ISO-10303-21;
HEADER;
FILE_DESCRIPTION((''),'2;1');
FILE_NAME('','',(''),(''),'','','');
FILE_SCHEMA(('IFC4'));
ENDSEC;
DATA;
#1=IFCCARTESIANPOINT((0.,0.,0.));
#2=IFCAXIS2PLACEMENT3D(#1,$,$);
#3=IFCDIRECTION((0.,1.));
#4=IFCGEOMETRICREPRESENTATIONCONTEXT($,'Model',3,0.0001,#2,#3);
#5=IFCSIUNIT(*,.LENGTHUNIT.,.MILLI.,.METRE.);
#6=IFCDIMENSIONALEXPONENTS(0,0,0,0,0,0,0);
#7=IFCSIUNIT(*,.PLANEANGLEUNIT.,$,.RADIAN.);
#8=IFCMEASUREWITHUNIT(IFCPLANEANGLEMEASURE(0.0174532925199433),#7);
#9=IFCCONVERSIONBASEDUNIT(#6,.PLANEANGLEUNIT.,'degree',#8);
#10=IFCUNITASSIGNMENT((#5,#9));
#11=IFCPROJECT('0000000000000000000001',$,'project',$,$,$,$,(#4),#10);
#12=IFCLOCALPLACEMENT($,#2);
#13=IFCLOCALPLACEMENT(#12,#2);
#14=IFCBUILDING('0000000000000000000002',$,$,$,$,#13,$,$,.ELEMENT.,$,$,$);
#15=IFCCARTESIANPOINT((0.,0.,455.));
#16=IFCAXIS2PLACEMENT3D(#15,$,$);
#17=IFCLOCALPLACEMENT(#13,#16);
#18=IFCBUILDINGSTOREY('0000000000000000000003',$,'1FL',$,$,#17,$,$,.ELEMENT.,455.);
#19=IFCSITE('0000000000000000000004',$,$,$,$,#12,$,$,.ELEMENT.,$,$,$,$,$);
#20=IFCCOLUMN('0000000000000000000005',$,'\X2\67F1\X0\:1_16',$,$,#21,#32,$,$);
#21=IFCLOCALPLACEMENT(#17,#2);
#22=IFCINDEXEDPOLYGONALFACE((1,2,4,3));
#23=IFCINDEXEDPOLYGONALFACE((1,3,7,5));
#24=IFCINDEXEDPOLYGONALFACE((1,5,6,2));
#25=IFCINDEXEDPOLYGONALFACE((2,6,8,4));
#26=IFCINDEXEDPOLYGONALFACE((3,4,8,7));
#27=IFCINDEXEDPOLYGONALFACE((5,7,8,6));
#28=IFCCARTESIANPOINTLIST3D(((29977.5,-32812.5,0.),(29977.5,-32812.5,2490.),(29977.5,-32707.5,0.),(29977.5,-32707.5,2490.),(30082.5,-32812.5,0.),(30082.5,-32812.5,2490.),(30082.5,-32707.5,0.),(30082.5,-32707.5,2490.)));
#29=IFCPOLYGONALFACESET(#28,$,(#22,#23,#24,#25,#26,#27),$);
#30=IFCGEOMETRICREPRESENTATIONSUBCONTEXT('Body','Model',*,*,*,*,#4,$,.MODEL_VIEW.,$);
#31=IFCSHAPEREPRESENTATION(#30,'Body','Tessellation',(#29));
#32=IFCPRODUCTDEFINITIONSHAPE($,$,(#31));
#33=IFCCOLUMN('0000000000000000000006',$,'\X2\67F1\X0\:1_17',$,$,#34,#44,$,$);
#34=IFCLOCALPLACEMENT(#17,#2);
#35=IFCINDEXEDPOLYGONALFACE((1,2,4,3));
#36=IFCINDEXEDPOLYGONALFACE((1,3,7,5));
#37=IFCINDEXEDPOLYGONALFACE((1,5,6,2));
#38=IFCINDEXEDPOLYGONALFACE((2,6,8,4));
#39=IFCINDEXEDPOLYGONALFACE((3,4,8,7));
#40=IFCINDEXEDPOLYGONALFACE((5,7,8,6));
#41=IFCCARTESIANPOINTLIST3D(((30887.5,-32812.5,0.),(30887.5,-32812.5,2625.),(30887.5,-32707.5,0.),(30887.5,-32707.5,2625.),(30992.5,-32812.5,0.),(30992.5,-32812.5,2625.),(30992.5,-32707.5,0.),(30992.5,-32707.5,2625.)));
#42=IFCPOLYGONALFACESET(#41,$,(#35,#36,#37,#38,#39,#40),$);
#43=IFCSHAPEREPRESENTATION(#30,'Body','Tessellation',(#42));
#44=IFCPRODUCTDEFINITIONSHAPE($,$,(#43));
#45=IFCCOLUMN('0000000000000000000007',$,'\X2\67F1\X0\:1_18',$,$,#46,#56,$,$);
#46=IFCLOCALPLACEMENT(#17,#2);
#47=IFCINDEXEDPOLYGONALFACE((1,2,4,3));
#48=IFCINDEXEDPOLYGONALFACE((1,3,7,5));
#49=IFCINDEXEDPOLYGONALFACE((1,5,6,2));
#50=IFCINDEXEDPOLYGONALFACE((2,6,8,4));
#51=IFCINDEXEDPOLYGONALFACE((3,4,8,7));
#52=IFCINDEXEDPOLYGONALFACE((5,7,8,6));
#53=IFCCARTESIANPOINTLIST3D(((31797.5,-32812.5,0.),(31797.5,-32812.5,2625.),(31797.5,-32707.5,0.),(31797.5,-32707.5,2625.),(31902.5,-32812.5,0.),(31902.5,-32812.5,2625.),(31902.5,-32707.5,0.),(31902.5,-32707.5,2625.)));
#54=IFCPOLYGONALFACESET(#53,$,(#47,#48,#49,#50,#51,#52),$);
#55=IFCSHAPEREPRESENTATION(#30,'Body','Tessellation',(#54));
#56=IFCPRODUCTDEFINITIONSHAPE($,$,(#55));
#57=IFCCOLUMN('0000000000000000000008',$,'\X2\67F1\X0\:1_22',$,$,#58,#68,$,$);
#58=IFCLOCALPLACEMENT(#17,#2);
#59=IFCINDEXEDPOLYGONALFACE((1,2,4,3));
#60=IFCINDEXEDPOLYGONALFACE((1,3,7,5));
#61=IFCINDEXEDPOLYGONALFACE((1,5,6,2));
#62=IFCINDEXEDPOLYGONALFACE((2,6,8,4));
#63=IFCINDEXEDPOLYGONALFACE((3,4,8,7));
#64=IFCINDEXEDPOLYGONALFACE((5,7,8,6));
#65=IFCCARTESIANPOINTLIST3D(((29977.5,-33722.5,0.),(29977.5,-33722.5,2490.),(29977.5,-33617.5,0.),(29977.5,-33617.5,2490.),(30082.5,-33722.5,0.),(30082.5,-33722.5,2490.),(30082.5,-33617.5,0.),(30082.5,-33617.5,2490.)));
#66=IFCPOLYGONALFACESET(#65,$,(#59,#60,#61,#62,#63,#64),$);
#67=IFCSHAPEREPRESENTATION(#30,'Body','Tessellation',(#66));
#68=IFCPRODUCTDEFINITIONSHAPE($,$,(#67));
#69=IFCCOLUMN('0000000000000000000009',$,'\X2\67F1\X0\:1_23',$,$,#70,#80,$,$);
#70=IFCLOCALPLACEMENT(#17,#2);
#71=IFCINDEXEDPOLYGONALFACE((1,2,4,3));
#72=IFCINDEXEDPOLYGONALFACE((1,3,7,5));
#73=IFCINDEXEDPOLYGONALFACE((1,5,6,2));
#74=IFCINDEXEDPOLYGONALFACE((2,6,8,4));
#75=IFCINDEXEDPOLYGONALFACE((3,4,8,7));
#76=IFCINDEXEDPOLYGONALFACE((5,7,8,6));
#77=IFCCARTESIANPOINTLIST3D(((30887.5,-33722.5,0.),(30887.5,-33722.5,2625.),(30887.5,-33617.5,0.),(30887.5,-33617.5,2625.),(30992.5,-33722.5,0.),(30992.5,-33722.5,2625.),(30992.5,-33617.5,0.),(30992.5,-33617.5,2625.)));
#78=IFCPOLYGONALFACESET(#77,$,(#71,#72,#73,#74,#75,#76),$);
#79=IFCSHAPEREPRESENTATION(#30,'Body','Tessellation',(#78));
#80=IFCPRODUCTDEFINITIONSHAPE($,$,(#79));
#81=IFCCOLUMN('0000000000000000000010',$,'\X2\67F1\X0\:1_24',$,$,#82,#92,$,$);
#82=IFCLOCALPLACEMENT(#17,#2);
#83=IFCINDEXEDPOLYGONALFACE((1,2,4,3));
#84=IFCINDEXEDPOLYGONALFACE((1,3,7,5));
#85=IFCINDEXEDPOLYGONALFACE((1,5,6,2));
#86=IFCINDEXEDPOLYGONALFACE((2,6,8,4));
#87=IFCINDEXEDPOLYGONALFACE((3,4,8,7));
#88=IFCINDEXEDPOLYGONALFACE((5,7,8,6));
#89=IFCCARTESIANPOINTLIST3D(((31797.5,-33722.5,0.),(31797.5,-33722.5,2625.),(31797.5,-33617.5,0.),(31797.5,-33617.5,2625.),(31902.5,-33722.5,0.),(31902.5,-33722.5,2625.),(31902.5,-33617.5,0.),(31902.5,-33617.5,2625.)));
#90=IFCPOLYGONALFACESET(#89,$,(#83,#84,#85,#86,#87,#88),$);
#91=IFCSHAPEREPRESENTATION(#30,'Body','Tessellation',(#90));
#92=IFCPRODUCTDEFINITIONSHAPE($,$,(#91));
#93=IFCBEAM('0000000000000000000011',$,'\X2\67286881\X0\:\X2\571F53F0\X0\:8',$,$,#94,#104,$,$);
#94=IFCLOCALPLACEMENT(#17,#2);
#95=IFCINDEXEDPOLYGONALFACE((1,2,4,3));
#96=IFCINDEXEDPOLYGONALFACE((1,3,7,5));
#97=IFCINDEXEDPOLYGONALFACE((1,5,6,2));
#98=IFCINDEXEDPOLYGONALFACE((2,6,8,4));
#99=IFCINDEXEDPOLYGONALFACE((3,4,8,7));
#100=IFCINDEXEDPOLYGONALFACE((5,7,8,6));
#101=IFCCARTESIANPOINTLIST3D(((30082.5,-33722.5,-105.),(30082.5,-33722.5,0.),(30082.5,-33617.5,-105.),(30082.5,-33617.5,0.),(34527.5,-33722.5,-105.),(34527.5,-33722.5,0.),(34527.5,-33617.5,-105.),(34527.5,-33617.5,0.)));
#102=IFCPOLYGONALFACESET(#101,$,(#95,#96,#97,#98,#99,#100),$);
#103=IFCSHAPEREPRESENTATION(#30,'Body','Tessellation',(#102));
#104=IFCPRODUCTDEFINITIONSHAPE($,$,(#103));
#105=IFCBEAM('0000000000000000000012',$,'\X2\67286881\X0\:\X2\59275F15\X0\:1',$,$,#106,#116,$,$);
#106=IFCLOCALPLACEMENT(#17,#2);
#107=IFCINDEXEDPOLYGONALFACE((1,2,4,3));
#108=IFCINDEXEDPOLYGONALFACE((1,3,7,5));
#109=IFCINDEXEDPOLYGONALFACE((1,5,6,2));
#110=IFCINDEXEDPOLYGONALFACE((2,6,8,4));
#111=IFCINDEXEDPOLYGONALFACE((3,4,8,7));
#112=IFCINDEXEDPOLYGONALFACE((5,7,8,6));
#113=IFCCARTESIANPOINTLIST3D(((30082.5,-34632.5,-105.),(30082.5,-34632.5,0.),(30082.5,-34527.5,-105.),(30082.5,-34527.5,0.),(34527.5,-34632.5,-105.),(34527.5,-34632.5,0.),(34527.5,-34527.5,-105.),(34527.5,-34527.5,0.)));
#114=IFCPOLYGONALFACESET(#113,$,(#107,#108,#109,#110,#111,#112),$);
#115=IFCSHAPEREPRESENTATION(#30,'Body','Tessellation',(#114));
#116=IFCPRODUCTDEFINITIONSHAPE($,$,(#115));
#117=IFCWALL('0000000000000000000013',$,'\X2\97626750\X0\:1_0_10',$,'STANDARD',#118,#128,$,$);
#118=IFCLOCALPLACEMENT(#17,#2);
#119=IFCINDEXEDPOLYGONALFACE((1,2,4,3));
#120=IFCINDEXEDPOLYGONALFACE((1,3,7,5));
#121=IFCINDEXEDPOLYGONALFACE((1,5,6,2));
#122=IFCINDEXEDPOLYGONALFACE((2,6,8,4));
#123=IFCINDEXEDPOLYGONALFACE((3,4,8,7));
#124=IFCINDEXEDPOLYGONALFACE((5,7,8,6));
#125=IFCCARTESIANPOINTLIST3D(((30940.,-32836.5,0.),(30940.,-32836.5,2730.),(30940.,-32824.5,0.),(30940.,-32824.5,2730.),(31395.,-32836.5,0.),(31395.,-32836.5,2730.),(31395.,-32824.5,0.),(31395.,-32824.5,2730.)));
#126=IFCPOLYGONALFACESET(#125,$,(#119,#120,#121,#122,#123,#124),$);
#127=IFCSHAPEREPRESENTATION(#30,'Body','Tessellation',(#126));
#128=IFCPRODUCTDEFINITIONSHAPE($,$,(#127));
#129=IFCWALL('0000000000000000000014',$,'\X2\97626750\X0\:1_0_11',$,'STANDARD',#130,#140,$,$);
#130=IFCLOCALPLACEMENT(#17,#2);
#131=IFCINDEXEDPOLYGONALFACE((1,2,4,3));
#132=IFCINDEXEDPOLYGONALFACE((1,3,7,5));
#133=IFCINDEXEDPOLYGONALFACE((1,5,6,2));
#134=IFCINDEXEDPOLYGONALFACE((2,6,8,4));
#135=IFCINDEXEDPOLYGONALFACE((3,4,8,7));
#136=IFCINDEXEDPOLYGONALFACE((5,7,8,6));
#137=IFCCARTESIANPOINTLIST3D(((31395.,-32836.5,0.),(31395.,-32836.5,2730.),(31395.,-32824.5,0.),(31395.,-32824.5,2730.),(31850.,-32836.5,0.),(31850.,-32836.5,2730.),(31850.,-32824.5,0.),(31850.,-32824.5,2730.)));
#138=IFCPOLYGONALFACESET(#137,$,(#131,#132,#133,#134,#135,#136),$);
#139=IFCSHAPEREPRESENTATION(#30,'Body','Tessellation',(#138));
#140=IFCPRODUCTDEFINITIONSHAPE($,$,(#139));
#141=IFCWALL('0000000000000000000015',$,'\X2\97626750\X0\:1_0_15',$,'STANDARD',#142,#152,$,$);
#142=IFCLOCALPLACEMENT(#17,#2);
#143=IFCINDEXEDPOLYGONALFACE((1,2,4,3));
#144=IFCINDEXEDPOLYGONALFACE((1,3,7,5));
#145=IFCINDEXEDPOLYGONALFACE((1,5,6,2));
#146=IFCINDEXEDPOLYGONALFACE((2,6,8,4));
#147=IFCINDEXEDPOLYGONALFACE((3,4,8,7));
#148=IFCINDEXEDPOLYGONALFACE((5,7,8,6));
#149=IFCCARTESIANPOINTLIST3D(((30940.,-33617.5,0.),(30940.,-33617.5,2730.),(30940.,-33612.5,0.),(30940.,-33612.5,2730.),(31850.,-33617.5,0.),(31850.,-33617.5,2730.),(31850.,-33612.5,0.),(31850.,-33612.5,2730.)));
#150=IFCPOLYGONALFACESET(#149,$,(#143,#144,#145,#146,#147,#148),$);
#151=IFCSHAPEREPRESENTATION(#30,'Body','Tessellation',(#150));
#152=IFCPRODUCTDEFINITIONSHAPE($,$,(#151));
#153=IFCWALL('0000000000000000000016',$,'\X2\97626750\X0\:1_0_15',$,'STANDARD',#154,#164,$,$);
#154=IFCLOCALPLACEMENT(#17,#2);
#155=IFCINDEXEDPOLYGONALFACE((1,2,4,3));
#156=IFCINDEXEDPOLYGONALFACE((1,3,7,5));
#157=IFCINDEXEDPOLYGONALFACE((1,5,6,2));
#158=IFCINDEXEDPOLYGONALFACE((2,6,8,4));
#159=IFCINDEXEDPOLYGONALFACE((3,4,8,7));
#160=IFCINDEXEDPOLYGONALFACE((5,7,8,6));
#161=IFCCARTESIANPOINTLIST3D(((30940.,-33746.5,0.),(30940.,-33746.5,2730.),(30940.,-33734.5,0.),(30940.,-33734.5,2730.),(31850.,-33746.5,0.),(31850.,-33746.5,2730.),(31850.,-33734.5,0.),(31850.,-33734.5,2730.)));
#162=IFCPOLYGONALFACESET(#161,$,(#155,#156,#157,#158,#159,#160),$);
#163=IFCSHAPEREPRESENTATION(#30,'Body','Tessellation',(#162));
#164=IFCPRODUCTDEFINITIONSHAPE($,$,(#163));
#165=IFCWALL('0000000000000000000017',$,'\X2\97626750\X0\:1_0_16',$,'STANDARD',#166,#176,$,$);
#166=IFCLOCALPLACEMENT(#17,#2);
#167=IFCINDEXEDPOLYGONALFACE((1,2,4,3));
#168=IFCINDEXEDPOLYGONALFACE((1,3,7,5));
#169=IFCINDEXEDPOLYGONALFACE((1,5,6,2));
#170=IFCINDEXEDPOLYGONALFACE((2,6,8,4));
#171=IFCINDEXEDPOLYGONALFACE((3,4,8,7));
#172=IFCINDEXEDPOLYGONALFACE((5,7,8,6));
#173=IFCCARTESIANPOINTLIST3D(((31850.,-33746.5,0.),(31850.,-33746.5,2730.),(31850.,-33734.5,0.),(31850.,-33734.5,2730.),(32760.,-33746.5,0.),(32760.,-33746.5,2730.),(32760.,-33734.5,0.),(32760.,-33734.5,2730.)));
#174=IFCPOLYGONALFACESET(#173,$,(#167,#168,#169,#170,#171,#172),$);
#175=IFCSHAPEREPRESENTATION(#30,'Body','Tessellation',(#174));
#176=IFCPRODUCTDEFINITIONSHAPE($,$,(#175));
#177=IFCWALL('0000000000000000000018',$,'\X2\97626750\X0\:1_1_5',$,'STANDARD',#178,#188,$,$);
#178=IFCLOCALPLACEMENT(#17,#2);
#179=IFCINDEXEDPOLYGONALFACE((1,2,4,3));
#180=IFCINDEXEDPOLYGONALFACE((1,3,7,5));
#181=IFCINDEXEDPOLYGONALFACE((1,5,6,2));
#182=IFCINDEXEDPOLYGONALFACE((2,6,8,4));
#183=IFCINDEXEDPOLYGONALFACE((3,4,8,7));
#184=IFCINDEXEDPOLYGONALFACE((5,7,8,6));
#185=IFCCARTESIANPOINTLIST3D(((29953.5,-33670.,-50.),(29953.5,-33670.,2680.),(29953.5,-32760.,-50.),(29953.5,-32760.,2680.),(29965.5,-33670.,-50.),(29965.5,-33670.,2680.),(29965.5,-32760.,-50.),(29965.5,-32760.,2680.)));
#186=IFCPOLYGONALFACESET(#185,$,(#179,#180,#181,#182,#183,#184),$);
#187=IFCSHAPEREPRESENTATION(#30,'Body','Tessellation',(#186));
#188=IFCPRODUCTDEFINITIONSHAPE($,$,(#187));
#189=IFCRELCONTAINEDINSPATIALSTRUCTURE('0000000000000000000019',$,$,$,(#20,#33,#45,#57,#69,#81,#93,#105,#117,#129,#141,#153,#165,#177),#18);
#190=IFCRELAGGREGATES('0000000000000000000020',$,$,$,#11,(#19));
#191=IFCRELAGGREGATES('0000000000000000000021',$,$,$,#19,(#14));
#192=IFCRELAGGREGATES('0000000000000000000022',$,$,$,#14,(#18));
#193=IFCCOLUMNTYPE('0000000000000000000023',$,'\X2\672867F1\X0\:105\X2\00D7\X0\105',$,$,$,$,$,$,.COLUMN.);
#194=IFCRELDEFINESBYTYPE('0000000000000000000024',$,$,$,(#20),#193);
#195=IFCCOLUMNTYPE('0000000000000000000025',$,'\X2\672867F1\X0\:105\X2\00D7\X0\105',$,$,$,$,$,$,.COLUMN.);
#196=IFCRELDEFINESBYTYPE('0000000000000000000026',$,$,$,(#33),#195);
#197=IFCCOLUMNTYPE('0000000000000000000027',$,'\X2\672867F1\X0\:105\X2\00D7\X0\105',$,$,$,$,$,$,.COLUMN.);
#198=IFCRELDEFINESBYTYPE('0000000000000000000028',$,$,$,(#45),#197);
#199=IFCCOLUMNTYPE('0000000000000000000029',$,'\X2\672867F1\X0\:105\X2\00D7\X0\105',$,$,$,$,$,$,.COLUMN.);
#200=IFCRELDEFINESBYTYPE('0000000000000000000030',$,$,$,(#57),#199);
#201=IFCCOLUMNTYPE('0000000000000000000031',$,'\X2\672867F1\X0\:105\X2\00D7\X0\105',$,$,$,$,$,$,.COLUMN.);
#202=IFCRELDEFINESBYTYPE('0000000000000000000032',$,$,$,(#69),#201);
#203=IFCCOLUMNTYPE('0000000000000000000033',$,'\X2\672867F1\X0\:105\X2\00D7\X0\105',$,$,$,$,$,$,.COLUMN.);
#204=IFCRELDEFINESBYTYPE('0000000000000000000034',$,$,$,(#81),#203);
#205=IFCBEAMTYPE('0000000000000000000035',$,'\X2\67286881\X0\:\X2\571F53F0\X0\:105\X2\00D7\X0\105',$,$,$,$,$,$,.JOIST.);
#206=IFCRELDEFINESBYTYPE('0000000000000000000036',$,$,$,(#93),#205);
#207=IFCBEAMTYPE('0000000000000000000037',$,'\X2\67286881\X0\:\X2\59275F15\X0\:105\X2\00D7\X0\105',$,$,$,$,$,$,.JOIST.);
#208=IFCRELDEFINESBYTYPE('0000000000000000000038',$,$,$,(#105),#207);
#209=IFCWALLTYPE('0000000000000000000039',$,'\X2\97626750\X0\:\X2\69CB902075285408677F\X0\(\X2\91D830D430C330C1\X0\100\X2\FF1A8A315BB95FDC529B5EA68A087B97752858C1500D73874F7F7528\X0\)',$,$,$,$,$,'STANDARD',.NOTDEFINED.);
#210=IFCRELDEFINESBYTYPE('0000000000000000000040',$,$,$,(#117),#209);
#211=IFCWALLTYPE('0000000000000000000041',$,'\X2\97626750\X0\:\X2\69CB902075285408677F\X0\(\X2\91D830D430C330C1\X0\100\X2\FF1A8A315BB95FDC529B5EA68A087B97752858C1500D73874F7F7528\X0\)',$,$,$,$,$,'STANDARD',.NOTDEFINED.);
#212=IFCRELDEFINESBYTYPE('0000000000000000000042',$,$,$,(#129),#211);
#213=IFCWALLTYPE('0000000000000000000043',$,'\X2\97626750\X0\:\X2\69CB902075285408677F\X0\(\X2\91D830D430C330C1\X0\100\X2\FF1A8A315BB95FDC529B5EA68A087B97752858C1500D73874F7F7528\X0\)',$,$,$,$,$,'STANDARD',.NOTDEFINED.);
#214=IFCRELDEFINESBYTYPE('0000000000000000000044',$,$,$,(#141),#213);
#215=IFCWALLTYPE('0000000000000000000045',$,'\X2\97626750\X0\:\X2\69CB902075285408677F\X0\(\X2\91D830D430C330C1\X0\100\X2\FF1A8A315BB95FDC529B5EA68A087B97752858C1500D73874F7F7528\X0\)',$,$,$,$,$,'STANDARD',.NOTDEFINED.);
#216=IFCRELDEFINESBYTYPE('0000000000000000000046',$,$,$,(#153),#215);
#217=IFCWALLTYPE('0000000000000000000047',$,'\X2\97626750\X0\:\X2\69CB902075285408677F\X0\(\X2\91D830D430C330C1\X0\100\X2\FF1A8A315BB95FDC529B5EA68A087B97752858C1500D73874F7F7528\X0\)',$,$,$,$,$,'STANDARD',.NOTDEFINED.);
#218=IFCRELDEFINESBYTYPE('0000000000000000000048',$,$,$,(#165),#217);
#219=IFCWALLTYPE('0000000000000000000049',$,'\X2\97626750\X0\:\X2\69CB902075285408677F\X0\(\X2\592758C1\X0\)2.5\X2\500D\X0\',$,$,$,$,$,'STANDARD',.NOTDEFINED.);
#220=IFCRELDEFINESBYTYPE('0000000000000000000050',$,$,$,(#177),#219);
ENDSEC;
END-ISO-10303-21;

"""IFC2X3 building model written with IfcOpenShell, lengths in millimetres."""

from ifc_helpers import new_model, entity, si_unit, converted_unit, direction, frame, origin, origin_with_axes, origin_2d, place, context, subcontext, project, spatial, polyline, rectangle, outline, extrude, type_object, element, save


model = new_model("IFC2X3")

# Units and contexts
model_context = context("Model", 3, precision=0.0001, world=origin(), true_north=direction((0.0, 1.0)))
body_context = subcontext(model_context, "Body", "Model", "MODEL_VIEW")
ifc_project = project(units=[si_unit("LENGTHUNIT", "METRE", prefix="MILLI"), converted_unit("PLANEANGLEUNIT", "degree", entity("IfcPlaneAngleMeasure", 0.0174532925199433), si_unit("PLANEANGLEUNIT", "RADIAN"), dimensions=[0, 0, 0, 0, 0, 0, 0])], contexts=[model_context])

# Site, building, storey
site_placement = place(None, origin())
site = spatial("IfcSite", under=ifc_project, at=site_placement, CompositionType="ELEMENT")
building_placement = place(site_placement, origin())
building = spatial("IfcBuilding", under=site, at=building_placement, CompositionType="ELEMENT")
storey_placement = place(building_placement, frame((0.0, 0.0, 455.0)))
storey = spatial("IfcBuildingStorey", under=building, at=storey_placement, Name="1FL", CompositionType="ELEMENT", Elevation=455.0)

# Columns
column_type_1 = type_object("IfcColumnType", Name="木柱:105×105", PredefinedType="COLUMN")
column_1_placement = place(storey_placement, frame((30030.0, -32760.0, 0.0)))
element("IfcColumn", 1, at=column_1_placement, inside=storey, type_object=column_type_1, Name="柱:1_16", context=body_context, shape_type="SweptSolid", body=[
    extrude(rectangle(XDim=105.0, YDim=105.0, at=origin_2d()), origin_with_axes(), (0.0, 0.0, 1.0), 2490.0),
])
column_type_2 = type_object("IfcColumnType", Name="木柱:105×105", PredefinedType="COLUMN")
column_2_placement = place(storey_placement, frame((30940.0, -32760.0, 0.0)))
element("IfcColumn", 2, at=column_2_placement, inside=storey, type_object=column_type_2, Name="柱:1_17", context=body_context, shape_type="SweptSolid", body=[
    extrude(rectangle(XDim=105.0, YDim=105.0, at=origin_2d()), origin_with_axes(), (0.0, 0.0, 1.0), 2625.0),
])
column_type_3 = type_object("IfcColumnType", Name="木柱:105×105", PredefinedType="COLUMN")
column_3_placement = place(storey_placement, frame((31850.0, -32760.0, 0.0)))
element("IfcColumn", 3, at=column_3_placement, inside=storey, type_object=column_type_3, Name="柱:1_18", context=body_context, shape_type="SweptSolid", body=[
    extrude(rectangle(XDim=105.0, YDim=105.0, at=origin_2d()), origin_with_axes(), (0.0, 0.0, 1.0), 2625.0),
])
column_type_4 = type_object("IfcColumnType", Name="木柱:105×105", PredefinedType="COLUMN")
column_4_placement = place(storey_placement, frame((30030.0, -33670.0, 0.0)))
element("IfcColumn", 4, at=column_4_placement, inside=storey, type_object=column_type_4, Name="柱:1_22", context=body_context, shape_type="SweptSolid", body=[
    extrude(rectangle(XDim=105.0, YDim=105.0, at=origin_2d()), origin_with_axes(), (0.0, 0.0, 1.0), 2490.0),
])
column_type_5 = type_object("IfcColumnType", Name="木柱:105×105", PredefinedType="COLUMN")
column_5_placement = place(storey_placement, frame((30940.0, -33670.0, 0.0)))
element("IfcColumn", 5, at=column_5_placement, inside=storey, type_object=column_type_5, Name="柱:1_23", context=body_context, shape_type="SweptSolid", body=[
    extrude(rectangle(XDim=105.0, YDim=105.0, at=origin_2d()), origin_with_axes(), (0.0, 0.0, 1.0), 2625.0),
])
column_type_6 = type_object("IfcColumnType", Name="木柱:105×105", PredefinedType="COLUMN")
column_6_placement = place(storey_placement, frame((31850.0, -33670.0, 0.0)))
element("IfcColumn", 6, at=column_6_placement, inside=storey, type_object=column_type_6, Name="柱:1_24", context=body_context, shape_type="SweptSolid", body=[
    extrude(rectangle(XDim=105.0, YDim=105.0, at=origin_2d()), origin_with_axes(), (0.0, 0.0, 1.0), 2625.0),
])

# Beams
beam_type_1 = type_object("IfcBeamType", Name="木梁:土台:105×105", PredefinedType="JOIST")
beam_1_placement = place(storey_placement, frame((30082.5, -33670.0, -52.5), z_axis=(1.0, 0.0, 0.0), x_axis=(0.0, 1.0, 0.0)))
element("IfcBeam", 7, at=beam_1_placement, inside=storey, type_object=beam_type_1, Name="木梁:土台:8", context=body_context, shape_type="SweptSolid", body=[
    extrude(rectangle(XDim=105.0, YDim=105.0, at=origin_2d()), origin_with_axes(), (0.0, 0.0, 1.0), 4445.0),
])
beam_type_2 = type_object("IfcBeamType", Name="木梁:大引:105×105", PredefinedType="JOIST")
beam_2_placement = place(storey_placement, frame((30082.5, -34580.0, -52.5), z_axis=(1.0, 0.0, 0.0), x_axis=(0.0, 1.0, 0.0)))
element("IfcBeam", 8, at=beam_2_placement, inside=storey, type_object=beam_type_2, Name="木梁:大引:1", context=body_context, shape_type="SweptSolid", body=[
    extrude(rectangle(XDim=105.0, YDim=105.0, at=origin_2d()), origin_with_axes(), (0.0, 0.0, 1.0), 4445.0),
])

# Walls
wall_type_1 = type_object("IfcWallType", Name="面材:構造用合板(釘ピッチ100：許容応力度計算用壁倍率使用)", ElementType="STANDARD", PredefinedType="NOTDEFINED")
wall_1_placement = place(storey_placement, frame((31167.5, -32824.5, 0.0), z_axis=(0.0, -1.0, 0.0), x_axis=(1.0, 0.0, 0.0)))
element("IfcWall", 9, at=wall_1_placement, inside=storey, type_object=wall_type_1, Name="面材:1_0_10", ObjectType="STANDARD", context=body_context, shape_type="SweptSolid", body=[
    extrude(outline(polyline([(227.5, 0.0, 0.0), (-227.5, 0.0, 0.0), (-227.5, 2730.0, 0.0), (227.5, 2730.0, 0.0), (227.5, 0.0, 0.0)])), origin_with_axes(), (0.0, 0.0, 1.0), 12.0),
])
wall_type_2 = type_object("IfcWallType", Name="面材:構造用合板(釘ピッチ100：許容応力度計算用壁倍率使用)", ElementType="STANDARD", PredefinedType="NOTDEFINED")
wall_2_placement = place(storey_placement, frame((31622.5, -32824.5, 0.0), z_axis=(0.0, -1.0, 0.0), x_axis=(1.0, 0.0, 0.0)))
element("IfcWall", 10, at=wall_2_placement, inside=storey, type_object=wall_type_2, Name="面材:1_0_11", ObjectType="STANDARD", context=body_context, shape_type="SweptSolid", body=[
    extrude(outline(polyline([(227.5, 0.0, 0.0), (-227.5, 0.0, 0.0), (-227.5, 2730.0, 0.0), (227.5, 2730.0, 0.0), (227.5, 0.0, 0.0)])), origin_with_axes(), (0.0, 0.0, 1.0), 12.0),
])
wall_type_3 = type_object("IfcWallType", Name="面材:構造用合板(釘ピッチ100：許容応力度計算用壁倍率使用)", ElementType="STANDARD", PredefinedType="NOTDEFINED")
wall_3_placement = place(storey_placement, frame((31395.0, -33612.5, 0.0), z_axis=(0.0, -1.0, 0.0), x_axis=(1.0, 0.0, 0.0)))
element("IfcWall", 11, at=wall_3_placement, inside=storey, type_object=wall_type_3, Name="面材:1_0_15", ObjectType="STANDARD", context=body_context, shape_type="SweptSolid", body=[
    extrude(outline(polyline([(455.0, 0.0, 0.0), (-455.0, 0.0, 0.0), (-455.0, 2730.0, 0.0), (455.0, 2730.0, 0.0), (455.0, 0.0, 0.0)])), origin_with_axes(), (0.0, 0.0, 1.0), 5.0),
])
wall_type_4 = type_object("IfcWallType", Name="面材:構造用合板(釘ピッチ100：許容応力度計算用壁倍率使用)", ElementType="STANDARD", PredefinedType="NOTDEFINED")
wall_4_placement = place(storey_placement, frame((31395.0, -33734.5, 0.0), z_axis=(0.0, -1.0, 0.0), x_axis=(1.0, 0.0, 0.0)))
element("IfcWall", 12, at=wall_4_placement, inside=storey, type_object=wall_type_4, Name="面材:1_0_15", ObjectType="STANDARD", context=body_context, shape_type="SweptSolid", body=[
    extrude(outline(polyline([(455.0, 0.0, 0.0), (-455.0, 0.0, 0.0), (-455.0, 2730.0, 0.0), (455.0, 2730.0, 0.0), (455.0, 0.0, 0.0)])), origin_with_axes(), (0.0, 0.0, 1.0), 12.0),
])
wall_type_5 = type_object("IfcWallType", Name="面材:構造用合板(釘ピッチ100：許容応力度計算用壁倍率使用)", ElementType="STANDARD", PredefinedType="NOTDEFINED")
wall_5_placement = place(storey_placement, frame((32305.0, -33734.5, 0.0), z_axis=(0.0, -1.0, 0.0), x_axis=(1.0, 0.0, 0.0)))
element("IfcWall", 13, at=wall_5_placement, inside=storey, type_object=wall_type_5, Name="面材:1_0_16", ObjectType="STANDARD", context=body_context, shape_type="SweptSolid", body=[
    extrude(outline(polyline([(455.0, 0.0, 0.0), (-455.0, 0.0, 0.0), (-455.0, 2730.0, 0.0), (455.0, 2730.0, 0.0), (455.0, 0.0, 0.0)])), origin_with_axes(), (0.0, 0.0, 1.0), 12.0),
])
wall_type_6 = type_object("IfcWallType", Name="面材:構造用合板(大壁)2.5倍", ElementType="STANDARD", PredefinedType="NOTDEFINED")
wall_6_placement = place(storey_placement, frame((29965.5, -33215.0, -50.0), z_axis=(-1.0, 0.0, 0.0), x_axis=(0.0, -1.0, 0.0)))
element("IfcWall", 14, at=wall_6_placement, inside=storey, type_object=wall_type_6, Name="面材:1_1_5", ObjectType="STANDARD", context=body_context, shape_type="SweptSolid", body=[
    extrude(outline(polyline([(455.0, 0.0, 0.0), (-455.0, 0.0, 0.0), (-455.0, 2730.0, 0.0), (455.0, 2730.0, 0.0), (455.0, 0.0, 0.0)])), origin_with_axes(), (0.0, 0.0, 1.0), 12.0),
])

save(model, "model.ifc")
